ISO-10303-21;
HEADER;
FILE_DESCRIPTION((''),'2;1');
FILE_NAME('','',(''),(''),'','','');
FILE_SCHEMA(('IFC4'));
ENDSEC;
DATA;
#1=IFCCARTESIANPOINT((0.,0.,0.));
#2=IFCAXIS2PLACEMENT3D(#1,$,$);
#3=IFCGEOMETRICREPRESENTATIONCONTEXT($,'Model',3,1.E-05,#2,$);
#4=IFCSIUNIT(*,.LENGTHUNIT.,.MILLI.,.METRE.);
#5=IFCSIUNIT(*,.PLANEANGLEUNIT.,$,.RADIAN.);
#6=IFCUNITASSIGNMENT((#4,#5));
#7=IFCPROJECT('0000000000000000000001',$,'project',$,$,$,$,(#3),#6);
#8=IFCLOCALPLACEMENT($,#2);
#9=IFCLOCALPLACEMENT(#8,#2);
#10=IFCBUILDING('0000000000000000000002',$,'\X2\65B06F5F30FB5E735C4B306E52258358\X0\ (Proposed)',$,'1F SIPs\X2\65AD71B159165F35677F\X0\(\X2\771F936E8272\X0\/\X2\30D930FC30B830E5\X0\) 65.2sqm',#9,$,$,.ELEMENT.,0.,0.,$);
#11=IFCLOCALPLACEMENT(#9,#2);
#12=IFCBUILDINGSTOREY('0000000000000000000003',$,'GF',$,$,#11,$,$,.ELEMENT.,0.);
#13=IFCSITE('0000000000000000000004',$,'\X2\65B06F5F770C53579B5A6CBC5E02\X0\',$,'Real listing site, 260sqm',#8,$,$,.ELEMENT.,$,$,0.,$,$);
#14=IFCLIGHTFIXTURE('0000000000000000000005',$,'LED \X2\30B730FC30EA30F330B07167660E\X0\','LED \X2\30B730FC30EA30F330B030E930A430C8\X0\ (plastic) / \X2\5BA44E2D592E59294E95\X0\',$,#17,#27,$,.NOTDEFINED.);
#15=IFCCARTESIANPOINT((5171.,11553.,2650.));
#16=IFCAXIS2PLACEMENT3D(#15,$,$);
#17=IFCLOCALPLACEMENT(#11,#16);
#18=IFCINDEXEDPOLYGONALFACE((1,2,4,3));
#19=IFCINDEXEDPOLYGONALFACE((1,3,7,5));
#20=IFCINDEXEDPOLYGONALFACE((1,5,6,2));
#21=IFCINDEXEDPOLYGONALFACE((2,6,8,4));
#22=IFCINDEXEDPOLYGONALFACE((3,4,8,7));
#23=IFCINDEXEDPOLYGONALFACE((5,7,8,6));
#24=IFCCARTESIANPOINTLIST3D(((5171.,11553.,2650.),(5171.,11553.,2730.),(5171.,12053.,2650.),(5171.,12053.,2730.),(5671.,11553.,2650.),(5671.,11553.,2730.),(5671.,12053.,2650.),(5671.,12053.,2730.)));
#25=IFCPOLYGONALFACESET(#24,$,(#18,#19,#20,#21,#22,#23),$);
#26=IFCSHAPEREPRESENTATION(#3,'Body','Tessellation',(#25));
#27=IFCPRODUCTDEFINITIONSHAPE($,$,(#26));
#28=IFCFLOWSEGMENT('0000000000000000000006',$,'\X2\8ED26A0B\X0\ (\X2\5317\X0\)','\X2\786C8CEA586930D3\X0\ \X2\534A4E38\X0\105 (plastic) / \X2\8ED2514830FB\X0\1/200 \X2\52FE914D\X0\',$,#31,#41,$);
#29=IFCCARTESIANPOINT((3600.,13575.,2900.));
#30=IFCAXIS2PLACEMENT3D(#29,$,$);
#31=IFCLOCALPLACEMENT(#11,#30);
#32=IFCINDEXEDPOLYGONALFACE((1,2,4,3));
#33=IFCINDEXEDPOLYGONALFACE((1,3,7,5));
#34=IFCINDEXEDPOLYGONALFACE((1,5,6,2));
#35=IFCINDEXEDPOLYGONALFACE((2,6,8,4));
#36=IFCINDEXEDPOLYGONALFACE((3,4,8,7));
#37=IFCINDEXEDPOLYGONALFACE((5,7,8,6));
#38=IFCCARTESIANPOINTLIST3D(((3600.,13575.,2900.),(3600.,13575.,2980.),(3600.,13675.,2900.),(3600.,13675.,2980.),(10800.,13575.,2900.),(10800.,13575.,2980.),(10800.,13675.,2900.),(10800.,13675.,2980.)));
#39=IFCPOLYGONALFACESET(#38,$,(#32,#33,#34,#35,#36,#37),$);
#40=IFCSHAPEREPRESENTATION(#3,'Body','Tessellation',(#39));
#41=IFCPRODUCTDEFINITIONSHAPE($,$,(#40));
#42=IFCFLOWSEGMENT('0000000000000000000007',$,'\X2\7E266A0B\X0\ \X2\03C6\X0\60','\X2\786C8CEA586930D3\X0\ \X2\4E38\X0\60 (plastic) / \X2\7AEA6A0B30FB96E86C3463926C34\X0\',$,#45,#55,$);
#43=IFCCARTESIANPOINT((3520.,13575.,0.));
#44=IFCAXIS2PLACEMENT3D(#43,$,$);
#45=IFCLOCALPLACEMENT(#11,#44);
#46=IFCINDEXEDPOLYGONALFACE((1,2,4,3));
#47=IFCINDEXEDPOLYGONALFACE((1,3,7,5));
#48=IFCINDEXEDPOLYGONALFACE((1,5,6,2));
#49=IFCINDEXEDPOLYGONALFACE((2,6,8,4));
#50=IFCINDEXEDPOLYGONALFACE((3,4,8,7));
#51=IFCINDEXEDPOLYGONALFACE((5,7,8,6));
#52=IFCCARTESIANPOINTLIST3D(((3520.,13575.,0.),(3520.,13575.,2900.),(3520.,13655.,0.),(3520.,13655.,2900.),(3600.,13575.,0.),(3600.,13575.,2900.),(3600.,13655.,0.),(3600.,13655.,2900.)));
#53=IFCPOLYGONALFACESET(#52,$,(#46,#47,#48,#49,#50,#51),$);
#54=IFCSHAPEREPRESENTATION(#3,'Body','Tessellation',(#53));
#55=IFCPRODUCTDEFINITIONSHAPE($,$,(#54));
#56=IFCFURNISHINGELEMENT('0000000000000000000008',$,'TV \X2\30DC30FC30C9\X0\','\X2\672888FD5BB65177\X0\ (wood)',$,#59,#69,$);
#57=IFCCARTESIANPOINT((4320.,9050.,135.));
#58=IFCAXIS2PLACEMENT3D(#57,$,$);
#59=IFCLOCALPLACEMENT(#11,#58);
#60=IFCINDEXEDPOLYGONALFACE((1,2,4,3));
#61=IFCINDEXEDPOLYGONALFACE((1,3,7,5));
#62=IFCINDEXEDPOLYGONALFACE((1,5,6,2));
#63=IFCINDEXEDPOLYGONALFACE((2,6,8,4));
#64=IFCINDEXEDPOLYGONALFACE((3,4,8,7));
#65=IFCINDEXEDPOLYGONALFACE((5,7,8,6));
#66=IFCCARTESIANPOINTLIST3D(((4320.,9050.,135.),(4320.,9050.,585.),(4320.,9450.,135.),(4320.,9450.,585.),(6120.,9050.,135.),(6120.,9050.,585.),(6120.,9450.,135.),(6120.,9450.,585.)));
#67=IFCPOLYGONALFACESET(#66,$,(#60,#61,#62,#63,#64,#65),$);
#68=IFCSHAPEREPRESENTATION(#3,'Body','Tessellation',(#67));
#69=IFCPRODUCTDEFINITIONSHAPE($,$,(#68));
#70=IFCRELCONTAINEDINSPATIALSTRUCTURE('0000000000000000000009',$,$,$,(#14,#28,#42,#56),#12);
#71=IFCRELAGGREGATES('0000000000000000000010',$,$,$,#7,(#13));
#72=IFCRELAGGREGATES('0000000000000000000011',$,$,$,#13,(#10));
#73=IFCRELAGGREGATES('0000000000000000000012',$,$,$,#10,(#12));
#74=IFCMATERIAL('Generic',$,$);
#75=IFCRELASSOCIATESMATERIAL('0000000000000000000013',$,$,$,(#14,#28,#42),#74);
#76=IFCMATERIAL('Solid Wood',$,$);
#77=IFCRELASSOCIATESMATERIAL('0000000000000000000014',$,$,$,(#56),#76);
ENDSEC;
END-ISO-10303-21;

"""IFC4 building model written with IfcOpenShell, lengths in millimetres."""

from ifc_helpers import new_model, si_unit, frame, frame_2d, origin, place, context, project, spatial, rectangle, extrude, material, element, save


model = new_model("IFC4")

# Units and contexts
model_context = context("Model", 3, precision=1e-05, world=origin())
ifc_project = project(units=[si_unit("LENGTHUNIT", "METRE", prefix="MILLI"), si_unit("PLANEANGLEUNIT", "RADIAN")], contexts=[model_context])

# Site, building, storey
site_placement = place(None, origin())
site = spatial("IfcSite", under=ifc_project, at=site_placement, Name="新潟県南魚沼市", ObjectType="Real listing site, 260sqm", CompositionType="ELEMENT", RefElevation=0.0)
building_placement = place(site_placement, origin())
building = spatial("IfcBuilding", under=site, at=building_placement, Name="新潟・平屋の別荘 (Proposed)", ObjectType="1F SIPs断熱外張板(真鍮色/ベージュ) 65.2sqm", CompositionType="ELEMENT", ElevationOfRefHeight=0.0, ElevationOfTerrain=0.0)
storey_placement = place(building_placement, origin())
storey = spatial("IfcBuildingStorey", under=building, at=storey_placement, Name="GF", CompositionType="ELEMENT", Elevation=0.0)

# Shared definitions
ifc_material_1 = material(Name="Solid Wood")

# Shared definitions
ifc_material_2 = material(Name="Generic")

# Light fixture
light_fixture_placement = place(storey_placement, frame((5171.0, 11553.0, 2650.0)))
element("IfcLightFixture", 1, at=light_fixture_placement, inside=storey, material=ifc_material_2, Name="LED シーリング照明", Description="LED シーリングライト (plastic) / 室中央天井", PredefinedType="NOTDEFINED", context=model_context, shape_type="SweptSolid", body=[
    extrude(rectangle(XDim=500.0, YDim=500.0, at=frame_2d((250.0, 250.0))), frame((5171.0, 11553.0, 2650.0)), (0.0, 0.0, 1.0), 80.0),
])

# Flow segments
flow_segment_1_placement = place(storey_placement, frame((3600.0, 13575.0, 2900.0)))
element("IfcFlowSegment", 2, at=flow_segment_1_placement, inside=storey, material=ifc_material_2, Name="軒樋 (北)", Description="硬質塩ビ 半丸105 (plastic) / 軒先・1/200 勾配", context=model_context, shape_type="SweptSolid", body=[
    extrude(rectangle(XDim=7200.0, YDim=100.0, at=frame_2d((3600.0, 50.0))), frame((3600.0, 13575.0, 2900.0)), (0.0, 0.0, 1.0), 80.0),
])
flow_segment_2_placement = place(storey_placement, frame((3520.0, 13575.0, 0.0)))
element("IfcFlowSegment", 3, at=flow_segment_2_placement, inside=storey, material=ifc_material_2, Name="縦樋 φ60", Description="硬質塩ビ 丸60 (plastic) / 竪樋・雨水排水", context=model_context, shape_type="SweptSolid", body=[
    extrude(rectangle(XDim=80.0, YDim=80.0, at=frame_2d((40.0, 40.0))), frame((3520.0, 13575.0, 0.0)), (0.0, 0.0, 1.0), 2900.0),
])

# Furnishing element
furnishing_placement = place(storey_placement, frame((4320.0, 9050.0, 135.0)))
element("IfcFurnishingElement", 4, at=furnishing_placement, inside=storey, material=ifc_material_1, Name="TV ボード", Description="木製家具 (wood)", context=model_context, shape_type="SweptSolid", body=[
    extrude(rectangle(XDim=1800.0, YDim=400.0, at=frame_2d((900.0, 200.0))), frame((4320.0, 9050.0, 135.0)), (0.0, 0.0, 1.0), 450.0),
])

save(model, "model.ifc")
